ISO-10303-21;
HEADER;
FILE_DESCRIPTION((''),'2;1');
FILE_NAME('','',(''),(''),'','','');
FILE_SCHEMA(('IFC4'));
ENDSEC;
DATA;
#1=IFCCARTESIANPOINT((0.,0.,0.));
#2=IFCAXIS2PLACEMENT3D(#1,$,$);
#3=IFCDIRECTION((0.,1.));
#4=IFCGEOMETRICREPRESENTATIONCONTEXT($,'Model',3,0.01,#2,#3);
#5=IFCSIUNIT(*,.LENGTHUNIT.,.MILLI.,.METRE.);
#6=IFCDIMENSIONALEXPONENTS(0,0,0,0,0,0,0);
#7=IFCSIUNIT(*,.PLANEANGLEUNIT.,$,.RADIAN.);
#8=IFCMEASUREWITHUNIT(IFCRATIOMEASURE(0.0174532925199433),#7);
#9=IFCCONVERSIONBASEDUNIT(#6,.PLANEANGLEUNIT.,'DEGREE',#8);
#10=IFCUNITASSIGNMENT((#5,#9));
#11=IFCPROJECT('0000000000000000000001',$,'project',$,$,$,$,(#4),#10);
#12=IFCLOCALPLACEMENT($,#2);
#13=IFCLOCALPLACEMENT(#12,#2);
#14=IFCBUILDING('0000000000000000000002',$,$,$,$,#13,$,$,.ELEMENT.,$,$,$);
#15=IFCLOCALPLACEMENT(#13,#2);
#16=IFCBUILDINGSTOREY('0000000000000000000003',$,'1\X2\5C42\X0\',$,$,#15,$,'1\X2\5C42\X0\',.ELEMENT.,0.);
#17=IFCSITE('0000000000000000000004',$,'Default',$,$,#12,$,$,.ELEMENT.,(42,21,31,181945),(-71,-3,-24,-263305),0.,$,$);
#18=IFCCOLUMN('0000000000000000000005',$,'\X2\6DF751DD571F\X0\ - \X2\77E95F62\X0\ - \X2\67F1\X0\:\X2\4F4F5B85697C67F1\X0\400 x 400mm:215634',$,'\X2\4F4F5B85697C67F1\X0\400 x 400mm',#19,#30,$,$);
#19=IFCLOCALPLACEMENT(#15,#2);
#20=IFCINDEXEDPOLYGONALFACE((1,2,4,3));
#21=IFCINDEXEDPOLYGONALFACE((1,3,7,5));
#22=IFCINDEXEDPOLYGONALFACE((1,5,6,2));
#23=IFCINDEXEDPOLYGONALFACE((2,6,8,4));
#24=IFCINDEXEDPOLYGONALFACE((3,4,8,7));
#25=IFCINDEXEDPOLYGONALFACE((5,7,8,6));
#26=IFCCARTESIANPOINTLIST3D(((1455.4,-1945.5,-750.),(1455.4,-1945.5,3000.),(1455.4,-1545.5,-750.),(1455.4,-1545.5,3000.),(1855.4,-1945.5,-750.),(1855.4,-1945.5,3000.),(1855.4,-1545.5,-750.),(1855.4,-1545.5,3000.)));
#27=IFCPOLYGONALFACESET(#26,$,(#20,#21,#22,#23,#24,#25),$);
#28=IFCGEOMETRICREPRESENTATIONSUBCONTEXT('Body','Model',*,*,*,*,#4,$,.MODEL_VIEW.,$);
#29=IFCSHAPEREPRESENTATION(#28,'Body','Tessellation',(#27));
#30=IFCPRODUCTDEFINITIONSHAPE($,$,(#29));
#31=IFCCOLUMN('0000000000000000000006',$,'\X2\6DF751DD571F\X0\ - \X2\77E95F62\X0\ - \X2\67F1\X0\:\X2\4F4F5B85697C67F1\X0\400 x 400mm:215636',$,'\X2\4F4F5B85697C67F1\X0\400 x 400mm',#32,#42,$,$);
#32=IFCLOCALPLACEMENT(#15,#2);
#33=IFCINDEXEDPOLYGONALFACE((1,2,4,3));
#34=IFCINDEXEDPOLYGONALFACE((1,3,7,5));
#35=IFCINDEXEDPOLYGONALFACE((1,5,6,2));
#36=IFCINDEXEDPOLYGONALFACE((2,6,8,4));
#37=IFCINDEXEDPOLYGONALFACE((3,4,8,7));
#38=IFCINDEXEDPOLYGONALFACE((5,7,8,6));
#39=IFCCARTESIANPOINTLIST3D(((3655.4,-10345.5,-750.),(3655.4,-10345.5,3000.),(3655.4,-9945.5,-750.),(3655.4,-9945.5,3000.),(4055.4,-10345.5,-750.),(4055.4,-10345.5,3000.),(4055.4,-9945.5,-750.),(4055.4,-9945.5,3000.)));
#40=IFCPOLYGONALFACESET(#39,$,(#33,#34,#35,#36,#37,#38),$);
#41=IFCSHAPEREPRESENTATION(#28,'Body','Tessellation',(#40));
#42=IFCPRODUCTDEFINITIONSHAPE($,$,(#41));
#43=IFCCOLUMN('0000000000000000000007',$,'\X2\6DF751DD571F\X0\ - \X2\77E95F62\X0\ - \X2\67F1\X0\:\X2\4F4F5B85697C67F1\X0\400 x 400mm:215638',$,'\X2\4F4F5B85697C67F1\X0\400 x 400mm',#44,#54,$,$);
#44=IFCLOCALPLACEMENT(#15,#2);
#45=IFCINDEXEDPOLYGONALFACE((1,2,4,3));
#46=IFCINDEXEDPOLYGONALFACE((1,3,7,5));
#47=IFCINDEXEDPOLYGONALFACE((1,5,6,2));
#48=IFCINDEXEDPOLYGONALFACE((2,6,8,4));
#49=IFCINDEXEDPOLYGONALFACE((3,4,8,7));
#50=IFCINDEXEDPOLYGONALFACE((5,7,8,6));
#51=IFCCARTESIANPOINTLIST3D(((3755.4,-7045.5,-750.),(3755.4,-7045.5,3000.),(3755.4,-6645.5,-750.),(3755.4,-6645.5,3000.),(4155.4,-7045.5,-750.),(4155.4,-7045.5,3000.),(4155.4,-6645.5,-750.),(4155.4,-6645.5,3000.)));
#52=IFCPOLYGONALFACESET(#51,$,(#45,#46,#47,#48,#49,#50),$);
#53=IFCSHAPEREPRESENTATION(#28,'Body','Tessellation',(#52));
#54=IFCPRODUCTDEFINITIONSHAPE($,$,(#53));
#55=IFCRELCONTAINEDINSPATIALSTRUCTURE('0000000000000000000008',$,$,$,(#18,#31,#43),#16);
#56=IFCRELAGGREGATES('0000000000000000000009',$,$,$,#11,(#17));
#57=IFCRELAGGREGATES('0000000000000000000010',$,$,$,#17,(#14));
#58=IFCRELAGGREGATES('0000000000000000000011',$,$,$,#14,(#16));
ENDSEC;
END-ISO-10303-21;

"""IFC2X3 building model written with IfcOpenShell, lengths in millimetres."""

from ifc_helpers import new_model, entity, si_unit, converted_unit, direction, frame, frame_2d, origin, origin_2d_with_axis, place, context, subcontext, project, spatial, rectangle, extrude, source, transform, mapped, element, save


model = new_model("IFC2X3")

# Units and contexts
model_context = context("Model", 3, precision=0.01, world=origin(), true_north=direction((0.0, 1.0)))
body_context = subcontext(model_context, "Body", "Model", "MODEL_VIEW")
ifc_project = project(units=[si_unit("LENGTHUNIT", "METRE", prefix="MILLI"), converted_unit("PLANEANGLEUNIT", "DEGREE", entity("IfcRatioMeasure", 0.0174532925199433), si_unit("PLANEANGLEUNIT", "RADIAN"), dimensions=[0, 0, 0, 0, 0, 0, 0])], contexts=[model_context])

# Site, building, storey
site_placement = place(None, origin())
site = spatial("IfcSite", under=ifc_project, at=site_placement, Name="Default", CompositionType="ELEMENT", RefLatitude=(42, 21, 31, 181945), RefLongitude=(-71, -3, -24, -263305), RefElevation=0.0)
building_placement = place(site_placement, origin())
building = spatial("IfcBuilding", under=site, at=building_placement, CompositionType="ELEMENT")
storey_placement = place(building_placement, origin())
storey = spatial("IfcBuildingStorey", under=building, at=storey_placement, Name="1层", LongName="1层", CompositionType="ELEMENT", Elevation=0.0)

# Columns
shared_shape_1 = source(origin(), body_context, "Body", "SweptSolid", [
    extrude(rectangle(XDim=400.0, YDim=400.0, at=frame_2d((0.0, 0.0), x_axis=(1.0, 0.0))), frame((1655.4, -1745.5, -750.0), z_axis=(0.0, 0.0, 1.0), x_axis=(0.0, -1.0, 0.0)), (0.0, 0.0, 1.0), 3750.0),
])
column_1_placement = place(storey_placement, origin())
element("IfcColumn", 1, at=column_1_placement, inside=storey, Name="混凝土 - 矩形 - 柱:住宅楼柱400 x 400mm:215634", ObjectType="住宅楼柱400 x 400mm", context=body_context, shape_type="MappedRepresentation", body=[
    mapped(shared_shape_1, transform((0.0, 0.0, 0.0), scale=1.0)),
])
shared_shape_2 = source(origin(), body_context, "Body", "SweptSolid", [
    extrude(rectangle(XDim=400.0, YDim=400.0, at=origin_2d_with_axis()), frame((3855.4, -10145.5, -750.0), z_axis=(0.0, 0.0, 1.0), x_axis=(0.0, -1.0, 0.0)), (0.0, 0.0, 1.0), 3750.0),
])
column_2_placement = place(storey_placement, origin())
element("IfcColumn", 2, at=column_2_placement, inside=storey, Name="混凝土 - 矩形 - 柱:住宅楼柱400 x 400mm:215636", ObjectType="住宅楼柱400 x 400mm", context=body_context, shape_type="MappedRepresentation", body=[
    mapped(shared_shape_2, transform((0.0, 0.0, 0.0), scale=1.0)),
])
shared_shape_3 = source(origin(), body_context, "Body", "SweptSolid", [
    extrude(rectangle(XDim=400.0, YDim=400.0, at=origin_2d_with_axis()), frame((3955.4, -6845.5, -750.0), z_axis=(0.0, 0.0, 1.0), x_axis=(0.0, -1.0, 0.0)), (0.0, 0.0, 1.0), 3750.0),
])
column_3_placement = place(storey_placement, origin())
element("IfcColumn", 3, at=column_3_placement, inside=storey, Name="混凝土 - 矩形 - 柱:住宅楼柱400 x 400mm:215638", ObjectType="住宅楼柱400 x 400mm", context=body_context, shape_type="MappedRepresentation", body=[
    mapped(shared_shape_3, transform((0.0, 0.0, 0.0), scale=1.0)),
])

save(model, "model.ifc")
